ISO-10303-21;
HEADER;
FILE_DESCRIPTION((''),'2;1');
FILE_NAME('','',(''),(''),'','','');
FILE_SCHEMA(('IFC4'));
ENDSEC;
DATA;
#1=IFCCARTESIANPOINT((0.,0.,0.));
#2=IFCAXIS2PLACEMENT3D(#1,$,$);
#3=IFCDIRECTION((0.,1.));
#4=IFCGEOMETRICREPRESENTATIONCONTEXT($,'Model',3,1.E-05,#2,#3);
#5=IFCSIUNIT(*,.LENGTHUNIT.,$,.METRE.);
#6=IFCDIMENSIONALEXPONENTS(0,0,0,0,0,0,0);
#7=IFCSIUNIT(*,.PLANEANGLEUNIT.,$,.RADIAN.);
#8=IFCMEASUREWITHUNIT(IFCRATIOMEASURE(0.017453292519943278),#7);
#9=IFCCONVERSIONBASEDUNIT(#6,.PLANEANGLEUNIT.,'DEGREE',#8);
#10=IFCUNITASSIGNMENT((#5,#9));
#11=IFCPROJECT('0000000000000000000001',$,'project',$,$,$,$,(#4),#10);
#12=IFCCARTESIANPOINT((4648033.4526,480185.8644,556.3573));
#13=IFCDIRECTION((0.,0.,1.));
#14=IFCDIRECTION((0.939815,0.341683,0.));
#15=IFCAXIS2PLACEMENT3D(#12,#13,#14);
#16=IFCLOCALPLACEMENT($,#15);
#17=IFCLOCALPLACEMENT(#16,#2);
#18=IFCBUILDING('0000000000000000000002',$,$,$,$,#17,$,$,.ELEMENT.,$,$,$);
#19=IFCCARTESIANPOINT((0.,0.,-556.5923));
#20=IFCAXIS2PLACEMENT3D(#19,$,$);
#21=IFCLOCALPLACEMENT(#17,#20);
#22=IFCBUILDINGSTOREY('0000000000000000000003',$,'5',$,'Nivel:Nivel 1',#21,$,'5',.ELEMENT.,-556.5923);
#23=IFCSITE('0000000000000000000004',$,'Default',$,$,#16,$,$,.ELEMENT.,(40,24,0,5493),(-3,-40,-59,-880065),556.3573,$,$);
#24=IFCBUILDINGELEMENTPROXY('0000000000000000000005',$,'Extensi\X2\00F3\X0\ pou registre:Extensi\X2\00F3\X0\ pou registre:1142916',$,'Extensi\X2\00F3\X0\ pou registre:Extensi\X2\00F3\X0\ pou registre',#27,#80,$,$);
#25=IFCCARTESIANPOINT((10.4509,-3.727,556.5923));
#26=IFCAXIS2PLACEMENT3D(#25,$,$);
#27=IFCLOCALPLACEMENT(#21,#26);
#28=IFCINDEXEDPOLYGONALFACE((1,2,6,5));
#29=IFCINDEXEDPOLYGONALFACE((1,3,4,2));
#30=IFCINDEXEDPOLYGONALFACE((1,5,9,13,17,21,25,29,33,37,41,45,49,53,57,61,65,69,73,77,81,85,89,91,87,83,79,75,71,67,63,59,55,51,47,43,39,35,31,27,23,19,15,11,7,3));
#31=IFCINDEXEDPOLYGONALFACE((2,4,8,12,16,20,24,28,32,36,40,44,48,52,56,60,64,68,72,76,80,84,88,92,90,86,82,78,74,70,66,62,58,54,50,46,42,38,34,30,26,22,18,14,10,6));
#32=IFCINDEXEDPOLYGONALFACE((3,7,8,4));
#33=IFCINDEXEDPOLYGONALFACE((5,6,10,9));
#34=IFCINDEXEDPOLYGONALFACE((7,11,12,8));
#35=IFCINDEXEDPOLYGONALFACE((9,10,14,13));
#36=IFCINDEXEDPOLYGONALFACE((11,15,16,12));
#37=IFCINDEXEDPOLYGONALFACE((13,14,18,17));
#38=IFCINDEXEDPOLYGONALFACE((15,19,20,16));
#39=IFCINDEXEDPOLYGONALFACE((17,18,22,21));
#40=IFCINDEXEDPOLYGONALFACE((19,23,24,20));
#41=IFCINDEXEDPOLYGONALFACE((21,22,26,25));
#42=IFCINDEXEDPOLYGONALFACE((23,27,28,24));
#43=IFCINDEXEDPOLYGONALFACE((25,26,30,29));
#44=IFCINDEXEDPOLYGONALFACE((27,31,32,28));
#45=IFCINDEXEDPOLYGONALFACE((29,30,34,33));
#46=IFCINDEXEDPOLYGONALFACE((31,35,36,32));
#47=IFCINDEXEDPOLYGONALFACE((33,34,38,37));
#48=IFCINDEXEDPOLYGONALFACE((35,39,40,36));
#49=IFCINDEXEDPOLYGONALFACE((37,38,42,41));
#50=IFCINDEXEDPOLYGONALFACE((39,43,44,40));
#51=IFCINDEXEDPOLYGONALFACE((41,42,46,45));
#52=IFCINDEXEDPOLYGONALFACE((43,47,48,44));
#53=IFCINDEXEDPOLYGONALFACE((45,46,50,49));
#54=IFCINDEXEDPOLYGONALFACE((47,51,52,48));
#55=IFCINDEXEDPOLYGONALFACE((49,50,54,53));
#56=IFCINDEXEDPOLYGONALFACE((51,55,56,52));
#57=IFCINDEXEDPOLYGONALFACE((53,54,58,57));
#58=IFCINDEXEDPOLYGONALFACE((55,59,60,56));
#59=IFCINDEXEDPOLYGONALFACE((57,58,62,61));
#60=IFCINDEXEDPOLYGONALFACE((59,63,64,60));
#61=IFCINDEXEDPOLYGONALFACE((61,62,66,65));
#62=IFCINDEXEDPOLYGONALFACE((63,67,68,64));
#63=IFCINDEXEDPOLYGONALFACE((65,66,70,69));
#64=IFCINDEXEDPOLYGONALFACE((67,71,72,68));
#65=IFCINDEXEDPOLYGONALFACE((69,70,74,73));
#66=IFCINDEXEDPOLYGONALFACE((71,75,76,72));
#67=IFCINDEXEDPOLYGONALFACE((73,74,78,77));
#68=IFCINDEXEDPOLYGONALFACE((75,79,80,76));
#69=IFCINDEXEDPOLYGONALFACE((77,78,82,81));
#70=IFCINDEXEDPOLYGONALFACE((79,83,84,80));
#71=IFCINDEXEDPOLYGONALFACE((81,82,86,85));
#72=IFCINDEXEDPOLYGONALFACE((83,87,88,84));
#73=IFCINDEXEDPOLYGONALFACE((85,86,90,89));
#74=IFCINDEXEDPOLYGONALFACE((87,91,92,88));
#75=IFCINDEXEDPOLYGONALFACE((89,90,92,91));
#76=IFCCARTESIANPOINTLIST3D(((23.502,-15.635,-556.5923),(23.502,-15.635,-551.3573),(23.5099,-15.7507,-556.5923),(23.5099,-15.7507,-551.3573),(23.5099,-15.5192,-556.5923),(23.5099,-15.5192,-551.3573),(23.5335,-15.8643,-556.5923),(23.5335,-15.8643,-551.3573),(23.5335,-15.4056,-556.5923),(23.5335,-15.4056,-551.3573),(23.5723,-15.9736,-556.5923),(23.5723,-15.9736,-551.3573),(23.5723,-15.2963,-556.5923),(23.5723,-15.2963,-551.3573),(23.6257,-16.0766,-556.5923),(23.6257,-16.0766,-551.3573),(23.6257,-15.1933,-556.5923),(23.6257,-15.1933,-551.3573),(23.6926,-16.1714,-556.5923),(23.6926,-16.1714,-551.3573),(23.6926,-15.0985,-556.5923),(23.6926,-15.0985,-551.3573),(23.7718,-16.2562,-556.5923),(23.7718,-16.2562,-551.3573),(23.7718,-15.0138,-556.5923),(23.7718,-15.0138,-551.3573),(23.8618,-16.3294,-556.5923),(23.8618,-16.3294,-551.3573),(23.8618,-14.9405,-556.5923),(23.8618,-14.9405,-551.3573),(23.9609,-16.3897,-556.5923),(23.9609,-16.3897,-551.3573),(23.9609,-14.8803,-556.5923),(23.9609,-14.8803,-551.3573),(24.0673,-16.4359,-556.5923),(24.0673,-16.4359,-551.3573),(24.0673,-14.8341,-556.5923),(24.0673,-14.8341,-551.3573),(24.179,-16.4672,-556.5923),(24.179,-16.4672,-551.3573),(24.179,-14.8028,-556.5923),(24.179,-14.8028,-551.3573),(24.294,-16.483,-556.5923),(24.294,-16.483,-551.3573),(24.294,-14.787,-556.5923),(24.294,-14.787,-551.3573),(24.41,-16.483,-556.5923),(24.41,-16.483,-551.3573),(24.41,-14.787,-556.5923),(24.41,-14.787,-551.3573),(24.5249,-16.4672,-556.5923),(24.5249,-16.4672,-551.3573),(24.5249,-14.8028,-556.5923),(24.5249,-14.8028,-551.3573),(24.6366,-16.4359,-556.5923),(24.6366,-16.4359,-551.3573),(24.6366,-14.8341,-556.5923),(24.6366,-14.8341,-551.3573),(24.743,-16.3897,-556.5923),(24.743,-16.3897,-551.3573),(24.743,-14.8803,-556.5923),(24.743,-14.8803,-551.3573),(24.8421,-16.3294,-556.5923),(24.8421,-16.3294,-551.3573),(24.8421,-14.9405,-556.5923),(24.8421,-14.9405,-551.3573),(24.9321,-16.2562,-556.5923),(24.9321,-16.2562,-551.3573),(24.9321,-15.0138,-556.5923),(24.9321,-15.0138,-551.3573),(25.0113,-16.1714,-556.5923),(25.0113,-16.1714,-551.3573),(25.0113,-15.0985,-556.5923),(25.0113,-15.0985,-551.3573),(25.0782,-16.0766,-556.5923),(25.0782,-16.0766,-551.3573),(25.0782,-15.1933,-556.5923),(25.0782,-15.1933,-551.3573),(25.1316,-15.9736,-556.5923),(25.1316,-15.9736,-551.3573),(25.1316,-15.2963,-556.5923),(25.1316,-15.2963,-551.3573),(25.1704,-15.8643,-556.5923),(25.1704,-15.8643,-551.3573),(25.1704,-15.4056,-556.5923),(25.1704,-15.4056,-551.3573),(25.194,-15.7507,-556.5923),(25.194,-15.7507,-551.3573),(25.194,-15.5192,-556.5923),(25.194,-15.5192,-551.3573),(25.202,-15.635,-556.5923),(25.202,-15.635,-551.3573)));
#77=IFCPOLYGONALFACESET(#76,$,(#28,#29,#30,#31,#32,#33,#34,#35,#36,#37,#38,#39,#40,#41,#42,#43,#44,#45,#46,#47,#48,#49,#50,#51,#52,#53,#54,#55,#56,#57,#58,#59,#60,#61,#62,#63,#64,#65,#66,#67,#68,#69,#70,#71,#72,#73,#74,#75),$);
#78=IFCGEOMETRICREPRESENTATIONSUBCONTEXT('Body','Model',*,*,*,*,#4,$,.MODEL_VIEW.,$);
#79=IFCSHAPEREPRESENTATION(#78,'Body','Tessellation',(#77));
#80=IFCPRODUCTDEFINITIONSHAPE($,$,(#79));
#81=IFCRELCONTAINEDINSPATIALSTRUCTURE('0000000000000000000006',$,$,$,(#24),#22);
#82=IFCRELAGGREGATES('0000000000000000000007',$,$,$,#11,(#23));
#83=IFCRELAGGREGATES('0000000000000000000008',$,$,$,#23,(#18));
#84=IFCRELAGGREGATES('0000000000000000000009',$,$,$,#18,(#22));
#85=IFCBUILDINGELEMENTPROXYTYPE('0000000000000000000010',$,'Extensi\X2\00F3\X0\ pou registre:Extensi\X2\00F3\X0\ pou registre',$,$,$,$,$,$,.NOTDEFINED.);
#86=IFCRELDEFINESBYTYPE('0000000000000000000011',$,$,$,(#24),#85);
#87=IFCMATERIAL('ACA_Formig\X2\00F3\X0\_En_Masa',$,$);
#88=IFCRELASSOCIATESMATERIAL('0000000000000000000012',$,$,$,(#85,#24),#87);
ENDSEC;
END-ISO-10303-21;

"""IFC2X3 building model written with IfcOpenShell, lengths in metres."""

from ifc_helpers import new_model, entity, si_unit, converted_unit, direction, frame, frame_2d, origin, place, context, subcontext, project, spatial, circle, extrude, source, transform, mapped, material, type_object, type_shapes, element, save


model = new_model("IFC2X3")

# Units and contexts
model_context = context("Model", 3, precision=1e-05, world=origin(), true_north=direction((0.0, 1.0)))
body_context = subcontext(model_context, "Body", "Model", "MODEL_VIEW")
ifc_project = project(units=[si_unit("LENGTHUNIT", "METRE"), converted_unit("PLANEANGLEUNIT", "DEGREE", entity("IfcRatioMeasure", 0.017453292519943278), si_unit("PLANEANGLEUNIT", "RADIAN"), dimensions=[0, 0, 0, 0, 0, 0, 0])], contexts=[model_context])

# Site, building, storey
site_placement = place(None, frame((4648033.4526, 480185.8644, 556.3573), z_axis=(0.0, 0.0, 1.0), x_axis=(0.939815, 0.341683, 0.0)))
site = spatial("IfcSite", under=ifc_project, at=site_placement, Name="Default", CompositionType="ELEMENT", RefLatitude=(40, 24, 0, 5493), RefLongitude=(-3, -40, -59, -880065), RefElevation=556.3573)
building_placement = place(site_placement, origin())
building = spatial("IfcBuilding", under=site, at=building_placement, CompositionType="ELEMENT")
storey_placement = place(building_placement, frame((0.0, 0.0, -556.5923)))
storey = spatial("IfcBuildingStorey", under=building, at=storey_placement, Name="5", ObjectType="Nivel:Nivel 1", LongName="5", CompositionType="ELEMENT", Elevation=-556.5923)

# Building element proxy
ifc_material_1 = material(Name="ACA_Formigó_En_Masa")
building_element_proxy_type_1 = type_object("IfcBuildingElementProxyType", Name="Extensió pou registre:Extensió pou registre", PredefinedType="NOTDEFINED", material=ifc_material_1)
shared_shape_1 = source(origin(), body_context, "Body", "SweptSolid", [
    extrude(circle(Radius=0.85, at=frame_2d((0.0, 0.0), x_axis=(1.0, 0.0))), frame((24.352, -15.635, -556.5923)), (0.0, 0.0, 1.0), 5.235),
])
type_shapes(building_element_proxy_type_1, [shared_shape_1])
proxy_1_placement = place(storey_placement, frame((10.4509, -3.727, 556.5923)))
element("IfcBuildingElementProxy", 1, at=proxy_1_placement, inside=storey, type_object=building_element_proxy_type_1, material=ifc_material_1, Name="Extensió pou registre:Extensió pou registre:1142916", ObjectType="Extensió pou registre:Extensió pou registre", context=body_context, shape_type="MappedRepresentation", body=[
    mapped(shared_shape_1, transform((0.0, 0.0, 0.0), scale=1.0)),
])

save(model, "model.ifc")
